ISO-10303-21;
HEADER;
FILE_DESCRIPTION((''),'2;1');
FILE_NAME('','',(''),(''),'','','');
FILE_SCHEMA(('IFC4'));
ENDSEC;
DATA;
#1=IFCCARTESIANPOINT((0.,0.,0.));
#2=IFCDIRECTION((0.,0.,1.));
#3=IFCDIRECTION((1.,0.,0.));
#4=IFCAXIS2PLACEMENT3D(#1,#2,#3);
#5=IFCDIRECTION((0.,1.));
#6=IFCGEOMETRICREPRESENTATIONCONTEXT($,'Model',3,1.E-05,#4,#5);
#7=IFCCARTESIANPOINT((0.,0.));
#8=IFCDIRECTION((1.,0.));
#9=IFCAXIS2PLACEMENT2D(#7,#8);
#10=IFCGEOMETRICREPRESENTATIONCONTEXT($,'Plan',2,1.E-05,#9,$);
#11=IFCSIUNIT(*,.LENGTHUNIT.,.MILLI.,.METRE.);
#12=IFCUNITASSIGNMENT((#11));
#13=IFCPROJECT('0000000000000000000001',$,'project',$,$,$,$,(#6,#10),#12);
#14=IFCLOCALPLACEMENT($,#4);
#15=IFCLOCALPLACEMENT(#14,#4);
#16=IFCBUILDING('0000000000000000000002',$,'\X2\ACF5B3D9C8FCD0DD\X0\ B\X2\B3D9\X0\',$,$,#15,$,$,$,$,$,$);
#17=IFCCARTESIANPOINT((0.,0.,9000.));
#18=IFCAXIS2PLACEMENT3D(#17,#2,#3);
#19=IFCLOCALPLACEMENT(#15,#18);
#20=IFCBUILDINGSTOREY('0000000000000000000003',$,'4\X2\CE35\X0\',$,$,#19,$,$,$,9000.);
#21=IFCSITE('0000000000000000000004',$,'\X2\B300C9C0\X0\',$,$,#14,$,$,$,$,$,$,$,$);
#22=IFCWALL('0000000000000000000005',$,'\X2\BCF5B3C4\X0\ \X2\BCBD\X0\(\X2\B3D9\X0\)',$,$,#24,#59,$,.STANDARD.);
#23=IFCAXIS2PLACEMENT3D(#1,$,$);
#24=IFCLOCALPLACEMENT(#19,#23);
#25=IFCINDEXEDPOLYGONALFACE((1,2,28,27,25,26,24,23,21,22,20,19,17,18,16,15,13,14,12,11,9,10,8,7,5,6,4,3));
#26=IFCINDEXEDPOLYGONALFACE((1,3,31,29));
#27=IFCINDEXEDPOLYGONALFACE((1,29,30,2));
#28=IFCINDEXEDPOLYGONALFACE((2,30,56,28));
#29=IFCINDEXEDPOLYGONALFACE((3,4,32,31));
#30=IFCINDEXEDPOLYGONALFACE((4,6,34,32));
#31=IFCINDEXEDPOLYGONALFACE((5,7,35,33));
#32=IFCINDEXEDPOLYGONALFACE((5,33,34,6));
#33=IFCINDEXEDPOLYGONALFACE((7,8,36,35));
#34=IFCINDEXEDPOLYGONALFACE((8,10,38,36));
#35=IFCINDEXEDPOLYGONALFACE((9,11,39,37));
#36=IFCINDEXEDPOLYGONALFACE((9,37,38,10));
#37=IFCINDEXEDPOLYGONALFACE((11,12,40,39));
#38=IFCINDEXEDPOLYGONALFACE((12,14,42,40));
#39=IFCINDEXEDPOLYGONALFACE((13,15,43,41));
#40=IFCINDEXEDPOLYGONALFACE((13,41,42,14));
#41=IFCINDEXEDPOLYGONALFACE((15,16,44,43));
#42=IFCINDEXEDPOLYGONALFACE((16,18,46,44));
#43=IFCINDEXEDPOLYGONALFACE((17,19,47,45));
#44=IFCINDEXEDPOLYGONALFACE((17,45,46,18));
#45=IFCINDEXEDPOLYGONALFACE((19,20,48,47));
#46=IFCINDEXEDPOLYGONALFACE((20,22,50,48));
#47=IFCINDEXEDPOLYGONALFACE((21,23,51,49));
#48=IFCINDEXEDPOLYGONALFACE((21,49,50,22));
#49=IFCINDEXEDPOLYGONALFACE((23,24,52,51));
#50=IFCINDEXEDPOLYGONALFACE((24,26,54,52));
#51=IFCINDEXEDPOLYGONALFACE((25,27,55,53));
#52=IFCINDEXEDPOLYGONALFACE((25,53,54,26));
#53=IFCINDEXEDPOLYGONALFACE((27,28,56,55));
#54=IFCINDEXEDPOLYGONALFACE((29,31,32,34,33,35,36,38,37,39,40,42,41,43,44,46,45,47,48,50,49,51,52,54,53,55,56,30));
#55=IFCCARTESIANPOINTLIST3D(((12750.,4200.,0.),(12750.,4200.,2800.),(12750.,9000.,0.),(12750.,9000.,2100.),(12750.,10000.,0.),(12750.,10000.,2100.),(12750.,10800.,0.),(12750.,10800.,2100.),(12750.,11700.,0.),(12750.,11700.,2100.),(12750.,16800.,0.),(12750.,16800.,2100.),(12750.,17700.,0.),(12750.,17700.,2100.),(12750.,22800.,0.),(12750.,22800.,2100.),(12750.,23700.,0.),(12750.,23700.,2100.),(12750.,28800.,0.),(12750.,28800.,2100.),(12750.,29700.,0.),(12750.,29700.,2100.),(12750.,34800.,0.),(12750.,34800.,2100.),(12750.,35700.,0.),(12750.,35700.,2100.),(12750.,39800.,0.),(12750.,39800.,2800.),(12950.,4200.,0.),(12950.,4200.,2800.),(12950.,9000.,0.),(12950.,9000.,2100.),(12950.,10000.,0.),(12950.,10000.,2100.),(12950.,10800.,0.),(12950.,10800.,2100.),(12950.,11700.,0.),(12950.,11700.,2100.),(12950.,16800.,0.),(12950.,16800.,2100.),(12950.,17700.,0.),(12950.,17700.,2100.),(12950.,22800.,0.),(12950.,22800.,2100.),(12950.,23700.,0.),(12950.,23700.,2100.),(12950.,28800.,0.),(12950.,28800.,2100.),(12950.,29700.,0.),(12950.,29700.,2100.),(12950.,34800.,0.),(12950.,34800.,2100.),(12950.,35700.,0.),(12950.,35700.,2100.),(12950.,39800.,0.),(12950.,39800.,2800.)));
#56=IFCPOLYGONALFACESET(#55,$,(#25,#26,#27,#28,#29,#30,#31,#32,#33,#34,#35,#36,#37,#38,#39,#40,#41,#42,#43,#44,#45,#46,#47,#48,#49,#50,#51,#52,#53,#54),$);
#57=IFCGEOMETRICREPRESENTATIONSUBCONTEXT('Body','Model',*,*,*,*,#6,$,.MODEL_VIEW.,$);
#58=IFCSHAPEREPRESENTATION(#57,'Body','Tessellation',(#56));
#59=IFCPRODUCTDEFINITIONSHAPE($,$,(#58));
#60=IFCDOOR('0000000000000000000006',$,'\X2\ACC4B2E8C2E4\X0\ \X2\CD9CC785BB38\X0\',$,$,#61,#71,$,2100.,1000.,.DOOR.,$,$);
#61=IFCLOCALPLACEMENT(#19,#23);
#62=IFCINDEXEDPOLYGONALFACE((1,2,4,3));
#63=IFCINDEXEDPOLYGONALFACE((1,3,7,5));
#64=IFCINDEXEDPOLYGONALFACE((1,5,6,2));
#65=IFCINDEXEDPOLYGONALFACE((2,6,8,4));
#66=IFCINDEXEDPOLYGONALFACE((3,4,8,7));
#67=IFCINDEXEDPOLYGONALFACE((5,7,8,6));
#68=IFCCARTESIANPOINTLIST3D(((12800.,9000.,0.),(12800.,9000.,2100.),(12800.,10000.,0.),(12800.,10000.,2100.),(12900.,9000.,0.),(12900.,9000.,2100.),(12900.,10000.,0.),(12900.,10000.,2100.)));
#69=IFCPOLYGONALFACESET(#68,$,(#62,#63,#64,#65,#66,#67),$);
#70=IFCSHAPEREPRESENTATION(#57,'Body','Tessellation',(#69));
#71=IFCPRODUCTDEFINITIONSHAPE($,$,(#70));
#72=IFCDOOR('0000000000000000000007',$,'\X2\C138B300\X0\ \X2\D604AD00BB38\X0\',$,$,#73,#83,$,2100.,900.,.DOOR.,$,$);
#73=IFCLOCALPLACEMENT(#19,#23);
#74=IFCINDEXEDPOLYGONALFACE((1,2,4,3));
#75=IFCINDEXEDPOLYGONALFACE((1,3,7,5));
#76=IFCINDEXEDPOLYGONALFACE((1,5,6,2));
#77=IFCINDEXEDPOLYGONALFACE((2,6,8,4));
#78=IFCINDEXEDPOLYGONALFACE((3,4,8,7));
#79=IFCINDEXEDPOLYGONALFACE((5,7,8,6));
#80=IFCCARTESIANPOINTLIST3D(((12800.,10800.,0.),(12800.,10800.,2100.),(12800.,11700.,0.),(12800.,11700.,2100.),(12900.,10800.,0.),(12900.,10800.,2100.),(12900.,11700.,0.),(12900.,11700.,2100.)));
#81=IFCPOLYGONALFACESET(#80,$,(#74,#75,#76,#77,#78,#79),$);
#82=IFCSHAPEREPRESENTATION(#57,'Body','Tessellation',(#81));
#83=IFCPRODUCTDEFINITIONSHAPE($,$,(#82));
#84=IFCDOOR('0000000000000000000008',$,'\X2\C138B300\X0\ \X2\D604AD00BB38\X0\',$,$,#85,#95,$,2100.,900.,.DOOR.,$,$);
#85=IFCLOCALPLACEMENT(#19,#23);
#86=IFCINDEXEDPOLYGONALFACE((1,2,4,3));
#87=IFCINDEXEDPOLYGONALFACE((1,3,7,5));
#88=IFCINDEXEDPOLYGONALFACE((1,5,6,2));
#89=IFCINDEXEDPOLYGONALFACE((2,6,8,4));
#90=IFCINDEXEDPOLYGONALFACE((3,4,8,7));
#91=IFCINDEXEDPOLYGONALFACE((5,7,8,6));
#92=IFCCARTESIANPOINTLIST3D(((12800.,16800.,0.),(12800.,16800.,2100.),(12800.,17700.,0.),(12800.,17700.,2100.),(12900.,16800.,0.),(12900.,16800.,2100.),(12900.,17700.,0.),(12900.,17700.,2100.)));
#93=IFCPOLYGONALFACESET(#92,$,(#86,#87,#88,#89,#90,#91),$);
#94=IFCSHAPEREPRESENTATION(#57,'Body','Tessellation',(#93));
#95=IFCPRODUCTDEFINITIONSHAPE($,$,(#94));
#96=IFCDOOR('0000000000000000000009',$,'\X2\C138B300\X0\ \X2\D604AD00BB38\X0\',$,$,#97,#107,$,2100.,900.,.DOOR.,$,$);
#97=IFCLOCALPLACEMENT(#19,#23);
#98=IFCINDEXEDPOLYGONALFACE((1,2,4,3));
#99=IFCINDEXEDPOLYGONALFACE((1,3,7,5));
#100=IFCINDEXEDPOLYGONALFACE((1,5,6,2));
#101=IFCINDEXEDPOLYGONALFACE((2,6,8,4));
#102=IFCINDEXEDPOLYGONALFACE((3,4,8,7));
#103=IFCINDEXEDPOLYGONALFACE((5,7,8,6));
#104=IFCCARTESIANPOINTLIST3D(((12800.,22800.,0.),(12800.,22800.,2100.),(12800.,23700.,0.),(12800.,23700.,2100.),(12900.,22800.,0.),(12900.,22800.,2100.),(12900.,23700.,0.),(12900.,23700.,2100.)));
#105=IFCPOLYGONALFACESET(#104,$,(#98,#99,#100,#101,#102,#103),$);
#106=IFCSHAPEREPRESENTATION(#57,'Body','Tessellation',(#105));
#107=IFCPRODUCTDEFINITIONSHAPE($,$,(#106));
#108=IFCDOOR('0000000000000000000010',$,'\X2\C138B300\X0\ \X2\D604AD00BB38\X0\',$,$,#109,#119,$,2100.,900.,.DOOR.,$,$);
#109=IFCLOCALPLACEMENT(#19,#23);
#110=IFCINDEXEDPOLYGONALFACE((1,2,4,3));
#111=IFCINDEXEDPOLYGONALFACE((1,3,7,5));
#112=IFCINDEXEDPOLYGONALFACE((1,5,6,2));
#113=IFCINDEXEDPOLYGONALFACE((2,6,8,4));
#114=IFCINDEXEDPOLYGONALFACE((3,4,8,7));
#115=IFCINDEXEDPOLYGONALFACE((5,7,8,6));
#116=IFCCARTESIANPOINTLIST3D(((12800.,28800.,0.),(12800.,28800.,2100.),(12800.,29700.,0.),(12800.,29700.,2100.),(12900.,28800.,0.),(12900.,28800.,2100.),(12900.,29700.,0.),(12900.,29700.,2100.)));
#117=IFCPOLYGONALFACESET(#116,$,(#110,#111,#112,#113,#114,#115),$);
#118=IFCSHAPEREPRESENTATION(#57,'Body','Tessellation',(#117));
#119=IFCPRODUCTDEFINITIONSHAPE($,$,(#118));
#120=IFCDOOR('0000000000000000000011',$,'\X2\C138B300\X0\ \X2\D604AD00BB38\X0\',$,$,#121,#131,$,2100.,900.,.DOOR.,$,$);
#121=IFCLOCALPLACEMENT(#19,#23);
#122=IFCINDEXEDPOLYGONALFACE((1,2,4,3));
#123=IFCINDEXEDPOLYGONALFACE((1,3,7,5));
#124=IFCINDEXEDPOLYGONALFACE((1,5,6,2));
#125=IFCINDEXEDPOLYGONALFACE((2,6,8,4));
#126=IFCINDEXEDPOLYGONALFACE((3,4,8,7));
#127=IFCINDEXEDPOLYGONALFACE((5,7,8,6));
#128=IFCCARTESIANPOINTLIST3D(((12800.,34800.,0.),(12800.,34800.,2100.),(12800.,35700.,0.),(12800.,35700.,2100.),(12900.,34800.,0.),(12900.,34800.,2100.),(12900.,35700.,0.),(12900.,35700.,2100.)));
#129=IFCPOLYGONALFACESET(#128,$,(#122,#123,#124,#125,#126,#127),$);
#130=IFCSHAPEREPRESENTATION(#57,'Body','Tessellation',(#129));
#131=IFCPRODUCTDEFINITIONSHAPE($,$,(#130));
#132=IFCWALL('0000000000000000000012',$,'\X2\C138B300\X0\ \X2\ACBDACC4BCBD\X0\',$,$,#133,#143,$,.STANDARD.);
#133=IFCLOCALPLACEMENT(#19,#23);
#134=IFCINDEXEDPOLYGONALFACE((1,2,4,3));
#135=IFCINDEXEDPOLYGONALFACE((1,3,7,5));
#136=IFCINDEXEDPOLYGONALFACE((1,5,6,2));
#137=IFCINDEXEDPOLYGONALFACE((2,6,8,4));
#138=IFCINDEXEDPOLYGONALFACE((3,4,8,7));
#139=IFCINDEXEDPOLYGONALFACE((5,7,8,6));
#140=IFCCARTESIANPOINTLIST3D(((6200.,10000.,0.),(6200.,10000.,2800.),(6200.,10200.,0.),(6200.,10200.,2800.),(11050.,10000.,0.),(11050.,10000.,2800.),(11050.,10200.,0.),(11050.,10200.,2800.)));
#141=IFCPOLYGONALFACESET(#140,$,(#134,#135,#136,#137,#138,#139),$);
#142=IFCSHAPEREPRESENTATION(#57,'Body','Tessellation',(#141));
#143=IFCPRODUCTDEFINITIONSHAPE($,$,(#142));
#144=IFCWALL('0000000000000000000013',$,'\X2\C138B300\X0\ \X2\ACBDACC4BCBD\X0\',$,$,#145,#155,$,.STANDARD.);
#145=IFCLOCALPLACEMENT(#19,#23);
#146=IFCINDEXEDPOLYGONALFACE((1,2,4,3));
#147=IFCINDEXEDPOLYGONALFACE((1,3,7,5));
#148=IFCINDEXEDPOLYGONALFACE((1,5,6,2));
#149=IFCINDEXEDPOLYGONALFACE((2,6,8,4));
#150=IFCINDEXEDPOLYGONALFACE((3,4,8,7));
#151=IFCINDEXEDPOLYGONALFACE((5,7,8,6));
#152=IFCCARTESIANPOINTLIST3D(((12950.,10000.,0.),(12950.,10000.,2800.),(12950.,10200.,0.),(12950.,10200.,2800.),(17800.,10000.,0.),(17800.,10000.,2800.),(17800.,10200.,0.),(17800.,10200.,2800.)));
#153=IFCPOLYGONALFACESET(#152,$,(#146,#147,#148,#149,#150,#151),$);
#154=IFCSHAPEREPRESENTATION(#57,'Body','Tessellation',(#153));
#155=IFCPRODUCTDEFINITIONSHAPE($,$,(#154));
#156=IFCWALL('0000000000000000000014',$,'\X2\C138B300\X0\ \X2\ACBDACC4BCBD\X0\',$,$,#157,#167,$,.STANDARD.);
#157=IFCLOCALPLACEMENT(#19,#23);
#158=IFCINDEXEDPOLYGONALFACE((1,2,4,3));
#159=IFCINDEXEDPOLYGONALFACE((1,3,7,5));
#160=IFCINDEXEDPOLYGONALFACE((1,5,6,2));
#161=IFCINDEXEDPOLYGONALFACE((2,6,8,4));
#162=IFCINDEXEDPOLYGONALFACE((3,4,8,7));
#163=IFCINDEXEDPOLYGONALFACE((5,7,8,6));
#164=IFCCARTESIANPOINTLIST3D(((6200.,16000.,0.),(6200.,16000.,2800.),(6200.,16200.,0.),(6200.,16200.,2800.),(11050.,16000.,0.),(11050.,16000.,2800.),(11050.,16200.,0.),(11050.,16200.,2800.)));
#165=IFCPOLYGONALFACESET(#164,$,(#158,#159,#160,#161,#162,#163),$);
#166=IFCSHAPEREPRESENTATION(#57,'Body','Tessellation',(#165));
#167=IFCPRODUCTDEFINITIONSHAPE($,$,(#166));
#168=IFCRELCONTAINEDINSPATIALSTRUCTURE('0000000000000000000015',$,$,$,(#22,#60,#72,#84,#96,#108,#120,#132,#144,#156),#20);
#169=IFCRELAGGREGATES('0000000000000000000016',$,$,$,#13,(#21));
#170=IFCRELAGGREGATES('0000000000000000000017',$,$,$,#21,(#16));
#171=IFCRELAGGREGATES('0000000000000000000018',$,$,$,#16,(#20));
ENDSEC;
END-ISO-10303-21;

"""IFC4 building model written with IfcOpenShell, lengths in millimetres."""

from ifc_helpers import new_model, si_unit, direction, frame, origin_with_axes, origin_2d_with_axis, place, context, subcontext, project, spatial, polyline, outline, extrude, element, fill, save


model = new_model("IFC4")

# Units and contexts
model_context = context("Model", 3, precision=1e-05, world=origin_with_axes(), true_north=direction((0.0, 1.0)))
plan_context = context("Plan", 2, precision=1e-05, world=origin_2d_with_axis())
body_context = subcontext(model_context, "Body", "Model", "MODEL_VIEW")
ifc_project = project(units=[si_unit("LENGTHUNIT", "METRE", prefix="MILLI")], contexts=[model_context, plan_context])

# Site, building, storey
site_placement = place(None, origin_with_axes())
site = spatial("IfcSite", under=ifc_project, at=site_placement, Name="대지")
building_placement = place(site_placement, origin_with_axes())
building = spatial("IfcBuilding", under=site, at=building_placement, Name="공동주택 B동")
storey_placement = place(building_placement, frame((0.0, 0.0, 9000.0), z_axis=(0.0, 0.0, 1.0), x_axis=(1.0, 0.0, 0.0)))
storey = spatial("IfcBuildingStorey", under=building, at=storey_placement, Name="4층", Elevation=9000.0)

# Wall, openings, doors
wall_1_placement = place(storey_placement, origin_with_axes())
wall_1 = element("IfcWall", 1, at=wall_1_placement, inside=storey, Name="복도 벽(동)", PredefinedType="STANDARD", context=body_context, shape_type="SweptSolid", body=[
    extrude(outline(polyline([(12750.0, 4200.0), (12750.0, 39800.0), (12950.0, 39800.0), (12950.0, 4200.0), (12750.0, 4200.0)])), origin_with_axes(), (0.0, 0.0, 1.0), 2800.0),
])
opening_1_placement = place(storey_placement, origin_with_axes())
opening_1 = element("IfcOpeningElement", 2, at=opening_1_placement, cuts=wall_1, PredefinedType="OPENING", context=body_context, shape_type="SweptSolid", body=[
    extrude(outline(polyline([(13000.0, 9000.0), (13000.0, 10000.0), (12700.0, 10000.0), (12700.0, 9000.0), (13000.0, 9000.0)])), origin_with_axes(), (0.0, 0.0, 1.0), 2100.0),
])
opening_2_placement = place(storey_placement, origin_with_axes())
opening_2 = element("IfcOpeningElement", 3, at=opening_2_placement, cuts=wall_1, PredefinedType="OPENING", context=body_context, shape_type="SweptSolid", body=[
    extrude(outline(polyline([(13000.0, 10800.0), (13000.0, 11700.0), (12700.0, 11700.0), (12700.0, 10800.0), (13000.0, 10800.0)])), origin_with_axes(), (0.0, 0.0, 1.0), 2100.0),
])
opening_3_placement = place(storey_placement, origin_with_axes())
opening_3 = element("IfcOpeningElement", 4, at=opening_3_placement, cuts=wall_1, PredefinedType="OPENING", context=body_context, shape_type="SweptSolid", body=[
    extrude(outline(polyline([(13000.0, 16800.0), (13000.0, 17700.0), (12700.0, 17700.0), (12700.0, 16800.0), (13000.0, 16800.0)])), origin_with_axes(), (0.0, 0.0, 1.0), 2100.0),
])
opening_4_placement = place(storey_placement, origin_with_axes())
opening_4 = element("IfcOpeningElement", 5, at=opening_4_placement, cuts=wall_1, PredefinedType="OPENING", context=body_context, shape_type="SweptSolid", body=[
    extrude(outline(polyline([(13000.0, 22800.0), (13000.0, 23700.0), (12700.0, 23700.0), (12700.0, 22800.0), (13000.0, 22800.0)])), origin_with_axes(), (0.0, 0.0, 1.0), 2100.0),
])
opening_5_placement = place(storey_placement, origin_with_axes())
opening_5 = element("IfcOpeningElement", 6, at=opening_5_placement, cuts=wall_1, PredefinedType="OPENING", context=body_context, shape_type="SweptSolid", body=[
    extrude(outline(polyline([(13000.0, 28800.0), (13000.0, 29700.0), (12700.0, 29700.0), (12700.0, 28800.0), (13000.0, 28800.0)])), origin_with_axes(), (0.0, 0.0, 1.0), 2100.0),
])
opening_6_placement = place(storey_placement, origin_with_axes())
opening_6 = element("IfcOpeningElement", 7, at=opening_6_placement, cuts=wall_1, PredefinedType="OPENING", context=body_context, shape_type="SweptSolid", body=[
    extrude(outline(polyline([(13000.0, 34800.0), (13000.0, 35700.0), (12700.0, 35700.0), (12700.0, 34800.0), (13000.0, 34800.0)])), origin_with_axes(), (0.0, 0.0, 1.0), 2100.0),
])
door_1_placement = place(storey_placement, origin_with_axes())
door_1 = element("IfcDoor", 8, at=door_1_placement, inside=storey, Name="계단실 출입문", OverallHeight=2100.0, OverallWidth=1000.0, PredefinedType="DOOR", context=body_context, shape_type="SweptSolid", body=[
    extrude(outline(polyline([(12900.0, 9000.0), (12900.0, 10000.0), (12800.0, 10000.0), (12800.0, 9000.0), (12900.0, 9000.0)])), origin_with_axes(), (0.0, 0.0, 1.0), 2100.0),
])
fill(opening_1, door_1)
door_2_placement = place(storey_placement, origin_with_axes())
door_2 = element("IfcDoor", 9, at=door_2_placement, inside=storey, Name="세대 현관문", OverallHeight=2100.0, OverallWidth=900.0, PredefinedType="DOOR", context=body_context, shape_type="SweptSolid", body=[
    extrude(outline(polyline([(12900.0, 10800.0), (12900.0, 11700.0), (12800.0, 11700.0), (12800.0, 10800.0), (12900.0, 10800.0)])), origin_with_axes(), (0.0, 0.0, 1.0), 2100.0),
])
fill(opening_2, door_2)
door_3_placement = place(storey_placement, origin_with_axes())
door_3 = element("IfcDoor", 10, at=door_3_placement, inside=storey, Name="세대 현관문", OverallHeight=2100.0, OverallWidth=900.0, PredefinedType="DOOR", context=body_context, shape_type="SweptSolid", body=[
    extrude(outline(polyline([(12900.0, 16800.0), (12900.0, 17700.0), (12800.0, 17700.0), (12800.0, 16800.0), (12900.0, 16800.0)])), origin_with_axes(), (0.0, 0.0, 1.0), 2100.0),
])
fill(opening_3, door_3)
door_4_placement = place(storey_placement, origin_with_axes())
door_4 = element("IfcDoor", 11, at=door_4_placement, inside=storey, Name="세대 현관문", OverallHeight=2100.0, OverallWidth=900.0, PredefinedType="DOOR", context=body_context, shape_type="SweptSolid", body=[
    extrude(outline(polyline([(12900.0, 22800.0), (12900.0, 23700.0), (12800.0, 23700.0), (12800.0, 22800.0), (12900.0, 22800.0)])), origin_with_axes(), (0.0, 0.0, 1.0), 2100.0),
])
fill(opening_4, door_4)
door_5_placement = place(storey_placement, origin_with_axes())
door_5 = element("IfcDoor", 12, at=door_5_placement, inside=storey, Name="세대 현관문", OverallHeight=2100.0, OverallWidth=900.0, PredefinedType="DOOR", context=body_context, shape_type="SweptSolid", body=[
    extrude(outline(polyline([(12900.0, 28800.0), (12900.0, 29700.0), (12800.0, 29700.0), (12800.0, 28800.0), (12900.0, 28800.0)])), origin_with_axes(), (0.0, 0.0, 1.0), 2100.0),
])
fill(opening_5, door_5)
door_6_placement = place(storey_placement, origin_with_axes())
door_6 = element("IfcDoor", 13, at=door_6_placement, inside=storey, Name="세대 현관문", OverallHeight=2100.0, OverallWidth=900.0, PredefinedType="DOOR", context=body_context, shape_type="SweptSolid", body=[
    extrude(outline(polyline([(12900.0, 34800.0), (12900.0, 35700.0), (12800.0, 35700.0), (12800.0, 34800.0), (12900.0, 34800.0)])), origin_with_axes(), (0.0, 0.0, 1.0), 2100.0),
])
fill(opening_6, door_6)

# Walls
wall_2_placement = place(storey_placement, origin_with_axes())
element("IfcWall", 14, at=wall_2_placement, inside=storey, Name="세대 경계벽", PredefinedType="STANDARD", context=body_context, shape_type="SweptSolid", body=[
    extrude(outline(polyline([(6200.0, 10200.0), (11050.0, 10200.0), (11050.0, 10000.0), (6200.0, 10000.0), (6200.0, 10200.0)])), origin_with_axes(), (0.0, 0.0, 1.0), 2800.0),
])
wall_3_placement = place(storey_placement, origin_with_axes())
element("IfcWall", 15, at=wall_3_placement, inside=storey, Name="세대 경계벽", PredefinedType="STANDARD", context=body_context, shape_type="SweptSolid", body=[
    extrude(outline(polyline([(12950.0, 10200.0), (17800.0, 10200.0), (17800.0, 10000.0), (12950.0, 10000.0), (12950.0, 10200.0)])), origin_with_axes(), (0.0, 0.0, 1.0), 2800.0),
])
wall_4_placement = place(storey_placement, origin_with_axes())
element("IfcWall", 16, at=wall_4_placement, inside=storey, Name="세대 경계벽", PredefinedType="STANDARD", context=body_context, shape_type="SweptSolid", body=[
    extrude(outline(polyline([(6200.0, 16200.0), (11050.0, 16200.0), (11050.0, 16000.0), (6200.0, 16000.0), (6200.0, 16200.0)])), origin_with_axes(), (0.0, 0.0, 1.0), 2800.0),
])

save(model, "model.ifc")
